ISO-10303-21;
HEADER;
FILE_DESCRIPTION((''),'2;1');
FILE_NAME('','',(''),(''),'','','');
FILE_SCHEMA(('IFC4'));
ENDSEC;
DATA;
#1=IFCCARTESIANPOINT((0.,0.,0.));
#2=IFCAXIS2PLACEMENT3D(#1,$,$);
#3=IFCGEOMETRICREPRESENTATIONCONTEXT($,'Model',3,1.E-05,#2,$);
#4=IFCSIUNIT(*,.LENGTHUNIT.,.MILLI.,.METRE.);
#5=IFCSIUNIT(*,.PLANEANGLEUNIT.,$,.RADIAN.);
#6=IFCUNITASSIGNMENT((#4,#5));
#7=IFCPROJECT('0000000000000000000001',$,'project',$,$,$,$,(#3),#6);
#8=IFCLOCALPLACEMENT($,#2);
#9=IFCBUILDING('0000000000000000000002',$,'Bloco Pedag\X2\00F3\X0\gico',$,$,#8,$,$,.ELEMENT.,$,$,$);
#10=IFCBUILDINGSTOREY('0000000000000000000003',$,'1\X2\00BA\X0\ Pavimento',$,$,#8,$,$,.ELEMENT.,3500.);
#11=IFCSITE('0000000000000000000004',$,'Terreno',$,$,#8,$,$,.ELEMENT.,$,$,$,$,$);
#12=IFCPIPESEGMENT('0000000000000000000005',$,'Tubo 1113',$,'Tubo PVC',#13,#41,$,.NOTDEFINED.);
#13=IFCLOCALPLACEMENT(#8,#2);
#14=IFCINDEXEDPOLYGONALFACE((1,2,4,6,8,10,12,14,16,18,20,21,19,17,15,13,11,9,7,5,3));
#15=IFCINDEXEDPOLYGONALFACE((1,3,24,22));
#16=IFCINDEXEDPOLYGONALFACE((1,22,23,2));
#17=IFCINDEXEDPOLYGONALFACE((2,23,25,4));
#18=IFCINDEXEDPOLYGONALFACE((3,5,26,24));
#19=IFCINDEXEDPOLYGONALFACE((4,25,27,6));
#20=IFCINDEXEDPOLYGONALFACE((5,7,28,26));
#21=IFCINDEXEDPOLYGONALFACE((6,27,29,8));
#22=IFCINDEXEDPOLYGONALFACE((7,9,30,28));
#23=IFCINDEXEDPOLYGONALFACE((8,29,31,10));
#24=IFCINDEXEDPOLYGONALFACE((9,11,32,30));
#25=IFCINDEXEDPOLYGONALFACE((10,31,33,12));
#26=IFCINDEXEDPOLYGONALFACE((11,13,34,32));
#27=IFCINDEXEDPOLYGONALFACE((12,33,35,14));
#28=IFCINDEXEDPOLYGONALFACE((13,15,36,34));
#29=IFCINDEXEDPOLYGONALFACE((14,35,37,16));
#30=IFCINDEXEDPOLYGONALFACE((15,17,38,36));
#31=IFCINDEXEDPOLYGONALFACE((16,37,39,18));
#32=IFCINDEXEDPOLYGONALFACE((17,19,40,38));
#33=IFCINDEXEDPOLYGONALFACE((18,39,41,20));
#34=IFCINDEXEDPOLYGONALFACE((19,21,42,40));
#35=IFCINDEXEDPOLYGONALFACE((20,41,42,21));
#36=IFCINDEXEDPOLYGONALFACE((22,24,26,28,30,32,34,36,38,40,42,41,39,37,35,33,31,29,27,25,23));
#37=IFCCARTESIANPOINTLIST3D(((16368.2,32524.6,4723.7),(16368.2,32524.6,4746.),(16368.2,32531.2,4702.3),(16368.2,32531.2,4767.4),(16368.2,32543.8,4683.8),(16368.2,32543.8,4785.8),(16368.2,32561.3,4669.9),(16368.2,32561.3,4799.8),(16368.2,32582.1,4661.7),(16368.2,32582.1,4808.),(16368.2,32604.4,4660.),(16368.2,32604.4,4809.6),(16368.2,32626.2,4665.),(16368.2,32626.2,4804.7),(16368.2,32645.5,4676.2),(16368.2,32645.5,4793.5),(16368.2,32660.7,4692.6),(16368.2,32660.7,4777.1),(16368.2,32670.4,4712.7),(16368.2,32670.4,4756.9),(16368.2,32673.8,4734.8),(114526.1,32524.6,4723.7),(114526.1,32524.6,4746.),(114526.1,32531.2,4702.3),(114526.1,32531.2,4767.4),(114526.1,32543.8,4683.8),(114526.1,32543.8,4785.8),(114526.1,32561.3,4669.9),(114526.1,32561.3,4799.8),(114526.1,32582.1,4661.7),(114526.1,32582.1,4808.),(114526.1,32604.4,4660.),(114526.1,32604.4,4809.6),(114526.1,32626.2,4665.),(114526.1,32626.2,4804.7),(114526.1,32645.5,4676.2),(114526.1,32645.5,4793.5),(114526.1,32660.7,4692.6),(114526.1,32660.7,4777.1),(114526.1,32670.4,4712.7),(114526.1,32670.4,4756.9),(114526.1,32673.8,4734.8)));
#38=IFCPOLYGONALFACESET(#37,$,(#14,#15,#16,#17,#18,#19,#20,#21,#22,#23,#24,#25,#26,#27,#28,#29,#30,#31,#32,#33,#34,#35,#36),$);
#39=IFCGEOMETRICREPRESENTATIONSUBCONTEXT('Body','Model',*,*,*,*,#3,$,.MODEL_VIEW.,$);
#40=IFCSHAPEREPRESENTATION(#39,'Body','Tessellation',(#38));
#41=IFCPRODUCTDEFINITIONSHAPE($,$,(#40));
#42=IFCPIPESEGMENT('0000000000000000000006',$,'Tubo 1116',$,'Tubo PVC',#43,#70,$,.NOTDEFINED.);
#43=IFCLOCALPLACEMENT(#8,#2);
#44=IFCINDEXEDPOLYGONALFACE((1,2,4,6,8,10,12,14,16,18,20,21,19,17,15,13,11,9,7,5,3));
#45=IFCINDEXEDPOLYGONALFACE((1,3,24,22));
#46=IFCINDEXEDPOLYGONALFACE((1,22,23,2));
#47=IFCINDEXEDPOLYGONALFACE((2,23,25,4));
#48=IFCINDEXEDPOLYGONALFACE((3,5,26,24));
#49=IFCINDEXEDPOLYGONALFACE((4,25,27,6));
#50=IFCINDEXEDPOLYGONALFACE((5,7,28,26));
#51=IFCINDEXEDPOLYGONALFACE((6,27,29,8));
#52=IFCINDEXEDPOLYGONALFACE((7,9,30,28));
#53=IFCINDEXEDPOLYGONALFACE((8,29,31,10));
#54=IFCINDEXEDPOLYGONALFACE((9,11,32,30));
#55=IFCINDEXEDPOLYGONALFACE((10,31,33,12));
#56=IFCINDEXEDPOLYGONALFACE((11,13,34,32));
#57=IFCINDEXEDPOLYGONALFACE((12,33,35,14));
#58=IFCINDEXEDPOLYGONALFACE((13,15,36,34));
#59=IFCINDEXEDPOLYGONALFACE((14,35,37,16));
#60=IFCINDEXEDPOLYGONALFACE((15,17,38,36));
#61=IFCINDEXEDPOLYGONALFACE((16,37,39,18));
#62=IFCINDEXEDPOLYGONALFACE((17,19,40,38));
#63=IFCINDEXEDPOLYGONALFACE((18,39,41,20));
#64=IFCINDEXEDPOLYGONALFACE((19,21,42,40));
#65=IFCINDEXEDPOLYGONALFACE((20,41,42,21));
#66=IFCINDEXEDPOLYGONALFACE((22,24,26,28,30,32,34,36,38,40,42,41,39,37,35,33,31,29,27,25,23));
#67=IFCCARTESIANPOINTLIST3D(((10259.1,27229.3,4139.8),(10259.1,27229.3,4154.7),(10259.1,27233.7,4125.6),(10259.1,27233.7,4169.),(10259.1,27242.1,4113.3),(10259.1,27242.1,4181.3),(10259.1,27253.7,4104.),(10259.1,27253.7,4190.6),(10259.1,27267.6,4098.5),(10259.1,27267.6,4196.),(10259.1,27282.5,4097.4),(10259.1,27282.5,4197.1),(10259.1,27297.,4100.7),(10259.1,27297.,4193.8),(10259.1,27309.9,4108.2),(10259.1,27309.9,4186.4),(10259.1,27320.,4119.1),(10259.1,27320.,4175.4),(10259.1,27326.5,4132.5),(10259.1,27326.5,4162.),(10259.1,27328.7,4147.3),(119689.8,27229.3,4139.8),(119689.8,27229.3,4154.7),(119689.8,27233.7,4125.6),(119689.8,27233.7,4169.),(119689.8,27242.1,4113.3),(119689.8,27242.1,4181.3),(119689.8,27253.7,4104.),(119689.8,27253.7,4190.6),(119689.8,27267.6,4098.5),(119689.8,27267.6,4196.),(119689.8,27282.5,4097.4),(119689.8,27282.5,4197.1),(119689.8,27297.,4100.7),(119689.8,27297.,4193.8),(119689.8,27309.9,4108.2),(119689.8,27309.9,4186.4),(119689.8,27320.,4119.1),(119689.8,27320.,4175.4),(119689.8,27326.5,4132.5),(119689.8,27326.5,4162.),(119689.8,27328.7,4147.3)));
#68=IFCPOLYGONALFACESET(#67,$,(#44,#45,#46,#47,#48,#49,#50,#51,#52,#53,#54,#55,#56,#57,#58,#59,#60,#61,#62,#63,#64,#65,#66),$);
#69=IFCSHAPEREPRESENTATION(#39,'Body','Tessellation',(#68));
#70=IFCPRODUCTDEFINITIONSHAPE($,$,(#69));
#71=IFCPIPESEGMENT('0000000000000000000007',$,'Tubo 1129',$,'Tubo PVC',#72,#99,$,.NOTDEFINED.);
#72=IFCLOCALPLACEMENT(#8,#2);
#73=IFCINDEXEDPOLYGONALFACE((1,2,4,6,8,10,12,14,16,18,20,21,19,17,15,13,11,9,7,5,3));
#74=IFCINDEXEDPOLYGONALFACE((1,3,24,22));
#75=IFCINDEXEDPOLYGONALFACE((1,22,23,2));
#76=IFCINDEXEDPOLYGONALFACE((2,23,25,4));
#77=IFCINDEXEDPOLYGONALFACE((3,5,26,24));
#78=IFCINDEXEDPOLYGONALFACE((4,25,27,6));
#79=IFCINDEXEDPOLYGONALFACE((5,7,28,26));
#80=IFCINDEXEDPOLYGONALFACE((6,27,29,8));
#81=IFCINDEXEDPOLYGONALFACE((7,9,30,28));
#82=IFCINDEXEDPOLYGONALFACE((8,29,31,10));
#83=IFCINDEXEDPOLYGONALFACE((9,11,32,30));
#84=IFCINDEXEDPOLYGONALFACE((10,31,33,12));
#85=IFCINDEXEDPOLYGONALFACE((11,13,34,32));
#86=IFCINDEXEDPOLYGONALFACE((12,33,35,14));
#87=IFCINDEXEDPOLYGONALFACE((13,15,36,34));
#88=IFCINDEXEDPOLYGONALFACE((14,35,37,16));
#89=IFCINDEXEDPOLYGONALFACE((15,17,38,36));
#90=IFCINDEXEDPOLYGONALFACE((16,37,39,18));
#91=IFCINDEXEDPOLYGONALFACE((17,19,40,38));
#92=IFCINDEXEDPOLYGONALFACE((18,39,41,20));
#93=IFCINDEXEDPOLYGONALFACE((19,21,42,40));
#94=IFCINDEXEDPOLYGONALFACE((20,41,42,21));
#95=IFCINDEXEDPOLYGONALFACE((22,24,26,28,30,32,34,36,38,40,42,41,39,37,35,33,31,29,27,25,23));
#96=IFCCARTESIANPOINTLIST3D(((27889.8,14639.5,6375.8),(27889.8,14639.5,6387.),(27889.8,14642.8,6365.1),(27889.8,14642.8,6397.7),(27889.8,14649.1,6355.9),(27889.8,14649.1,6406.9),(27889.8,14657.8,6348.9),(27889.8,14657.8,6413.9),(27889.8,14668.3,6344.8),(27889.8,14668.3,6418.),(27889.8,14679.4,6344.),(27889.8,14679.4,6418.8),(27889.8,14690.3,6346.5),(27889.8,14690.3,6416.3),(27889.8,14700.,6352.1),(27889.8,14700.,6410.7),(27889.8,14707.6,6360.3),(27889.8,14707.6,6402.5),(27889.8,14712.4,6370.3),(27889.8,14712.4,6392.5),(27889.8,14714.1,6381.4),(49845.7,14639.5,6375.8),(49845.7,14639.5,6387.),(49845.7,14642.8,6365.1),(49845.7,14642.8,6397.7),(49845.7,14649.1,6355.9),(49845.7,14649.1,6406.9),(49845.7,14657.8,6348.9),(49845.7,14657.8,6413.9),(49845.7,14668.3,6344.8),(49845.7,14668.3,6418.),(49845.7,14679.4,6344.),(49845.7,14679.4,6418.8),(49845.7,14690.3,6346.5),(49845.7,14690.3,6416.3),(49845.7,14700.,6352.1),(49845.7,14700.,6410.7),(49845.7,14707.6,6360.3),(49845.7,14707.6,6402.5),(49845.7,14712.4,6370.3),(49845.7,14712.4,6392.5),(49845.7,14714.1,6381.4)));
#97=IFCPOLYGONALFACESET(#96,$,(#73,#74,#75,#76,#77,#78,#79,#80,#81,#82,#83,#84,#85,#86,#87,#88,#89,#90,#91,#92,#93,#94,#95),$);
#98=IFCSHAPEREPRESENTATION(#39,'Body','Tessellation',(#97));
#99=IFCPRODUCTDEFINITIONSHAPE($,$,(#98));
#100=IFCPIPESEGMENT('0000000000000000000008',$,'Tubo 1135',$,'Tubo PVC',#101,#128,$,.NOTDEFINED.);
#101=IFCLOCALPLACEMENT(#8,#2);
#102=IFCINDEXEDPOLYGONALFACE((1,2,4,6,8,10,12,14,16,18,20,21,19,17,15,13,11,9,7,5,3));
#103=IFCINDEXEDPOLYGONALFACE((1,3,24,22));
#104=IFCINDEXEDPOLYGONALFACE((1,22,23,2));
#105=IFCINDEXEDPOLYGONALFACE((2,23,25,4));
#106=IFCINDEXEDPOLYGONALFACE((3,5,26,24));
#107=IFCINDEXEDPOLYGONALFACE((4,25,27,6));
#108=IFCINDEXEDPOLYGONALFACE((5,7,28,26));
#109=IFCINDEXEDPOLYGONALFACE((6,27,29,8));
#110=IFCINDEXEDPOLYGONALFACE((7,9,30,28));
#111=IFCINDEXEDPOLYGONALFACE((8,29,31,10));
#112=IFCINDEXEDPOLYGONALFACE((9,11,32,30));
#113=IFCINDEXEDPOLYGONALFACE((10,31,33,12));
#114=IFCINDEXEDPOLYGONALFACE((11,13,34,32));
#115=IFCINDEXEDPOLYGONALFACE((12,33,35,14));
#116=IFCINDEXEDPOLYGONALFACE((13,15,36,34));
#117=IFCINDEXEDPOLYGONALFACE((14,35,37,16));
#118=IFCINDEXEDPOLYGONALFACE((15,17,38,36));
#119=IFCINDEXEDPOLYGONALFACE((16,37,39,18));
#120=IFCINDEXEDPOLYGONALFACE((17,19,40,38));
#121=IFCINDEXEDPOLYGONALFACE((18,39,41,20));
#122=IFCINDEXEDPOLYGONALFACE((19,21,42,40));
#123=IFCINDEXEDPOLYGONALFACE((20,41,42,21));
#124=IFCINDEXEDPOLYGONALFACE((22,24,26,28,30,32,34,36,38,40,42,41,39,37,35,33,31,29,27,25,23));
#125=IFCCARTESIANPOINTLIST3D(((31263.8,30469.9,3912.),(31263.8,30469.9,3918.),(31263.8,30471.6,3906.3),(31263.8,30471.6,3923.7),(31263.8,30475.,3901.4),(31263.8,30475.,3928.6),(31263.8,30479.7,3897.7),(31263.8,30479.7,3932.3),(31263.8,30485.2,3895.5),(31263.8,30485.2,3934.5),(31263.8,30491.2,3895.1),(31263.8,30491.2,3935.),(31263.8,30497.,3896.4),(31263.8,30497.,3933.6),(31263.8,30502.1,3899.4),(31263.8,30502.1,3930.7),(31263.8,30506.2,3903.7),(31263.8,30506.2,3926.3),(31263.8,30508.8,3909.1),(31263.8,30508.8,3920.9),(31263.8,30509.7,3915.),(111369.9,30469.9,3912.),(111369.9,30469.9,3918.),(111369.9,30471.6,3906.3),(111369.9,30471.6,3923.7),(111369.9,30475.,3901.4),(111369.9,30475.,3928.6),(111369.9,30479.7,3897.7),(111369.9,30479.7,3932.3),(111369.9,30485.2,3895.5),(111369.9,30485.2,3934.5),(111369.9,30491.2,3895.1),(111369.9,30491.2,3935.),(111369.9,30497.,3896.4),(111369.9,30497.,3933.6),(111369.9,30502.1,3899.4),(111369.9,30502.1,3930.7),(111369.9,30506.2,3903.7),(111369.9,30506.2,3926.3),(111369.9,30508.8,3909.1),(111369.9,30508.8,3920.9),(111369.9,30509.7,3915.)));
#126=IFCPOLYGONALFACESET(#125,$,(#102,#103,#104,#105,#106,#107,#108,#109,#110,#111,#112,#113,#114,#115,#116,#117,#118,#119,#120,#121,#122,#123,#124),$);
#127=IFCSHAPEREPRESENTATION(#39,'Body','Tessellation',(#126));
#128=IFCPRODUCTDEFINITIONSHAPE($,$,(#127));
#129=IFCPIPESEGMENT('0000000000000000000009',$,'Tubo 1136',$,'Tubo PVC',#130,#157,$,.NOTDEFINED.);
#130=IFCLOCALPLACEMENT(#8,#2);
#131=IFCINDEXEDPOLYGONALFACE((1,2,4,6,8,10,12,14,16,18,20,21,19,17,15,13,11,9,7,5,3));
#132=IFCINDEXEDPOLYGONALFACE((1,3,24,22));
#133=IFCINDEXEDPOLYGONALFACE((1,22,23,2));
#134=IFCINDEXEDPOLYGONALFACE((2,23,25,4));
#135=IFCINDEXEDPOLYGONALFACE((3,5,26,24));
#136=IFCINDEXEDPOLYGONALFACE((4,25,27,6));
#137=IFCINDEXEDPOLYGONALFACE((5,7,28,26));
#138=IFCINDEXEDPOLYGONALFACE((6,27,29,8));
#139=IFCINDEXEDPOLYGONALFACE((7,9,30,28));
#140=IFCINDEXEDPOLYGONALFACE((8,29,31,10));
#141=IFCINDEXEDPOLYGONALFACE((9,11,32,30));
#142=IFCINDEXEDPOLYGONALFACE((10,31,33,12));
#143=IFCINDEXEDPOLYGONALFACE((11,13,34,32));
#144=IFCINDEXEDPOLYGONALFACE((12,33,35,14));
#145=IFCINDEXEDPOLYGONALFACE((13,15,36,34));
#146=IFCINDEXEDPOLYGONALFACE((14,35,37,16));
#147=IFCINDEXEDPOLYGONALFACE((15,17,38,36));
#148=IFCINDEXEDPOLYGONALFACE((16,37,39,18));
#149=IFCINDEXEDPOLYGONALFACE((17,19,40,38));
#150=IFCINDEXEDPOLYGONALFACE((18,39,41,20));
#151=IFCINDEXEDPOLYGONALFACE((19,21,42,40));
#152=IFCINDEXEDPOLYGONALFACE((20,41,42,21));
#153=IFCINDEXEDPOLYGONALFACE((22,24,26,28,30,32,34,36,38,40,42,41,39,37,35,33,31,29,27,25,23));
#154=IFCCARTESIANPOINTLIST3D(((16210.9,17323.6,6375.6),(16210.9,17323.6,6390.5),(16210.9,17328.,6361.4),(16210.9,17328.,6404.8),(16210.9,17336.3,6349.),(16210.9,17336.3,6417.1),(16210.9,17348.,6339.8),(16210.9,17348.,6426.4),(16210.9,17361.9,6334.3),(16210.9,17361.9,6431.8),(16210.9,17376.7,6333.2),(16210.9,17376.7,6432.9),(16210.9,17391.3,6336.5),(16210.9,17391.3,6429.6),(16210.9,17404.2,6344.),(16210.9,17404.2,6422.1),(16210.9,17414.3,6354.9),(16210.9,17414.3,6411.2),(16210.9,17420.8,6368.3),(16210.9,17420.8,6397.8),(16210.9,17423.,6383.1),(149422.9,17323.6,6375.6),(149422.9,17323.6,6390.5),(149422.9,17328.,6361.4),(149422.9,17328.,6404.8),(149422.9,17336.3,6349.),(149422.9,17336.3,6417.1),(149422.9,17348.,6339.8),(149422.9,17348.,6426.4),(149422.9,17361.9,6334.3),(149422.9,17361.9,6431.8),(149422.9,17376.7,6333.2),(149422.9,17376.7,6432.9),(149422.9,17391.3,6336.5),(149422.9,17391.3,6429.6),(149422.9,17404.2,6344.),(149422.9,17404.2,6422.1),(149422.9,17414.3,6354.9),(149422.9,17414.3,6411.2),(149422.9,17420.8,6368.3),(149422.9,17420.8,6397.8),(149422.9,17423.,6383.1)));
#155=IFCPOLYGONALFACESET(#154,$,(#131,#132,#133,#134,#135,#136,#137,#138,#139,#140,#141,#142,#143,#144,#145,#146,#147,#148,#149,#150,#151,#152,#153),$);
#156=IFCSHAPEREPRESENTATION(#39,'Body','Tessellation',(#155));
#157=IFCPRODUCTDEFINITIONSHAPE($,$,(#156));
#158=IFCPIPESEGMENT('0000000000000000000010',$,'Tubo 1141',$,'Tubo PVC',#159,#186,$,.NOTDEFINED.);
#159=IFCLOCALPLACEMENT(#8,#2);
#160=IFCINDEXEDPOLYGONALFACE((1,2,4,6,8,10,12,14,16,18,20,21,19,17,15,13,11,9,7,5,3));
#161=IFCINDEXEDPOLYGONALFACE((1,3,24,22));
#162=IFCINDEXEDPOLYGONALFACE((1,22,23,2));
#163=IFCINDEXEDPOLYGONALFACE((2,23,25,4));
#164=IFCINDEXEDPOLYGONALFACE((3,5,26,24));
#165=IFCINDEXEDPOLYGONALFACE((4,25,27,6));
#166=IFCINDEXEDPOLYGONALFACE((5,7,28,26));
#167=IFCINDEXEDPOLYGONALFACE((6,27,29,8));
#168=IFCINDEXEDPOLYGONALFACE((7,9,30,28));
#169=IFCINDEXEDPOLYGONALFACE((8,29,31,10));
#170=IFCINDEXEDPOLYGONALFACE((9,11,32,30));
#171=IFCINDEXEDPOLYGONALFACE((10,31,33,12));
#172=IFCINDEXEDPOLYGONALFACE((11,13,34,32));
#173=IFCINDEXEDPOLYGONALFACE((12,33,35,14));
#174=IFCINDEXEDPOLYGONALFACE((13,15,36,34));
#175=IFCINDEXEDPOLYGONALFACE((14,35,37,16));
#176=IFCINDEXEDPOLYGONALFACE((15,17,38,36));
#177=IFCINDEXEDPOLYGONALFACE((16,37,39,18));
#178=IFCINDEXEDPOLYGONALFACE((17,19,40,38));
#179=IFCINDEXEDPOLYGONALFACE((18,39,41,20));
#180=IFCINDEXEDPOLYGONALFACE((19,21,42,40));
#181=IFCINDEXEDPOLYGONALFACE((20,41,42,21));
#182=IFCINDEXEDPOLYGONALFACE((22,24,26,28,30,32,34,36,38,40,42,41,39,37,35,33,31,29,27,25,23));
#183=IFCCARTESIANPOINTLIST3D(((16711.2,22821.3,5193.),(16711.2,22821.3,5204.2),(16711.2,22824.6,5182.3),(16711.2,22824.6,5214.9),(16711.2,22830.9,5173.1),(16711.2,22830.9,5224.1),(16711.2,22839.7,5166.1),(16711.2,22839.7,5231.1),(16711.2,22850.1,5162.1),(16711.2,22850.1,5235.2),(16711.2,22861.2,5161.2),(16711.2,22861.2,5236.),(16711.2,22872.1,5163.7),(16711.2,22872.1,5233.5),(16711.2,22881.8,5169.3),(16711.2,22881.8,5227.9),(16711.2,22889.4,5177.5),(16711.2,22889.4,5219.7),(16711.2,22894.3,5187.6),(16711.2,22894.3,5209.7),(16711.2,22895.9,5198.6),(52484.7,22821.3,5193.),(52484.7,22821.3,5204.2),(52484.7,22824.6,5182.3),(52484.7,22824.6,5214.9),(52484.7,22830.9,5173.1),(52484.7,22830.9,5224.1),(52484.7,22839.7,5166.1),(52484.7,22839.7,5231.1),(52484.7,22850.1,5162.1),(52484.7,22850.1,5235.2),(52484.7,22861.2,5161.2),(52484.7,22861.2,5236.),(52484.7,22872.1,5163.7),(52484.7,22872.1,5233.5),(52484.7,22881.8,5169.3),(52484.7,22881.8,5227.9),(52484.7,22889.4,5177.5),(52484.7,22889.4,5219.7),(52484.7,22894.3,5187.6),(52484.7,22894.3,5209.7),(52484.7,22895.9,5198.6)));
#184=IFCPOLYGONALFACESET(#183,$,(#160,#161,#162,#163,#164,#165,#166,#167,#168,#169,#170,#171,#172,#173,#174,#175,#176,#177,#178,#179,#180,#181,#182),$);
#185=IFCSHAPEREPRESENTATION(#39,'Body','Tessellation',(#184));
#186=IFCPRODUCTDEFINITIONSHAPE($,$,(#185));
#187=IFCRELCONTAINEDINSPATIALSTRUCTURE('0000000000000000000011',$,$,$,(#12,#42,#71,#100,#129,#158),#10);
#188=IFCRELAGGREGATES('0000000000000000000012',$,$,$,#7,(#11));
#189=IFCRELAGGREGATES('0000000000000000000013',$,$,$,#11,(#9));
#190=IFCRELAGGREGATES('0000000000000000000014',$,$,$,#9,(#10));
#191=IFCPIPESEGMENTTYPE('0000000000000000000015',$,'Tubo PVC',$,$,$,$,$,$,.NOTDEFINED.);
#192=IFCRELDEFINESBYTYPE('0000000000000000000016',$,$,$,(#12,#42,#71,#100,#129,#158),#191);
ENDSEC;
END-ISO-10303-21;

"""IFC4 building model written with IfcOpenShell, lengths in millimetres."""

from ifc_helpers import new_model, si_unit, frame, origin, origin_2d, place, context, subcontext, project, spatial, circle, extrude, type_object, element, save


model = new_model("IFC4")

# Units and contexts
model_context = context("Model", 3, precision=1e-05, world=origin())
body_context = subcontext(model_context, "Body", "Model", "MODEL_VIEW")
ifc_project = project(units=[si_unit("LENGTHUNIT", "METRE", prefix="MILLI"), si_unit("PLANEANGLEUNIT", "RADIAN")], contexts=[model_context])

# Site, building, storey
placement = place(None, origin())
site = spatial("IfcSite", under=ifc_project, at=placement, Name="Terreno", CompositionType="ELEMENT")
building = spatial("IfcBuilding", under=site, at=placement, Name="Bloco Pedagógico", CompositionType="ELEMENT")
storey = spatial("IfcBuildingStorey", under=building, at=placement, Name="1º Pavimento", CompositionType="ELEMENT", Elevation=3500.0)

# Pipe segments
pipe_segment_type = type_object("IfcPipeSegmentType", Name="Tubo PVC", PredefinedType="NOTDEFINED")
pipe_segment_1_placement = place(None, frame((16368.2, 32598.8, 4734.8), z_axis=(1.0, 0.0, 0.0), x_axis=(0.0, 1.0, 0.0)))
element("IfcPipeSegment", 1, at=pipe_segment_1_placement, inside=storey, type_object=pipe_segment_type, Name="Tubo 1113", ObjectType="Tubo PVC", PredefinedType="NOTDEFINED", context=body_context, shape_type="SweptSolid", body=[
    extrude(circle(Radius=75.0, at=origin_2d()), None, (0.0, 0.0, 1.0), 98157.8),
])
pipe_segment_2_placement = place(None, frame((10259.1, 27278.7, 4147.3), z_axis=(1.0, 0.0, 0.0), x_axis=(0.0, 1.0, 0.0)))
element("IfcPipeSegment", 2, at=pipe_segment_2_placement, inside=storey, type_object=pipe_segment_type, Name="Tubo 1116", ObjectType="Tubo PVC", PredefinedType="NOTDEFINED", context=body_context, shape_type="SweptSolid", body=[
    extrude(circle(Radius=50.0, at=origin_2d()), None, (0.0, 0.0, 1.0), 109430.6),
])
pipe_segment_3_placement = place(None, frame((27889.8, 14676.6, 6381.4), z_axis=(1.0, 0.0, 0.0), x_axis=(0.0, 1.0, 0.0)))
element("IfcPipeSegment", 3, at=pipe_segment_3_placement, inside=storey, type_object=pipe_segment_type, Name="Tubo 1129", ObjectType="Tubo PVC", PredefinedType="NOTDEFINED", context=body_context, shape_type="SweptSolid", body=[
    extrude(circle(Radius=37.5, at=origin_2d()), None, (0.0, 0.0, 1.0), 21955.9),
])
pipe_segment_4_placement = place(None, frame((31263.8, 30489.7, 3915.0), z_axis=(1.0, 0.0, 0.0), x_axis=(0.0, 1.0, 0.0)))
element("IfcPipeSegment", 4, at=pipe_segment_4_placement, inside=storey, type_object=pipe_segment_type, Name="Tubo 1135", ObjectType="Tubo PVC", PredefinedType="NOTDEFINED", context=body_context, shape_type="SweptSolid", body=[
    extrude(circle(Radius=20.0, at=origin_2d()), None, (0.0, 0.0, 1.0), 80106.1),
])
pipe_segment_5_placement = place(None, frame((16210.9, 17373.0, 6383.1), z_axis=(1.0, 0.0, 0.0), x_axis=(0.0, 1.0, 0.0)))
element("IfcPipeSegment", 5, at=pipe_segment_5_placement, inside=storey, type_object=pipe_segment_type, Name="Tubo 1136", ObjectType="Tubo PVC", PredefinedType="NOTDEFINED", context=body_context, shape_type="SweptSolid", body=[
    extrude(circle(Radius=50.0, at=origin_2d()), None, (0.0, 0.0, 1.0), 133212.0),
])
pipe_segment_6_placement = place(None, frame((16711.2, 22858.4, 5198.6), z_axis=(1.0, 0.0, 0.0), x_axis=(0.0, 1.0, 0.0)))
element("IfcPipeSegment", 6, at=pipe_segment_6_placement, inside=storey, type_object=pipe_segment_type, Name="Tubo 1141", ObjectType="Tubo PVC", PredefinedType="NOTDEFINED", context=body_context, shape_type="SweptSolid", body=[
    extrude(circle(Radius=37.5, at=origin_2d()), None, (0.0, 0.0, 1.0), 35773.6),
])

save(model, "model.ifc")
